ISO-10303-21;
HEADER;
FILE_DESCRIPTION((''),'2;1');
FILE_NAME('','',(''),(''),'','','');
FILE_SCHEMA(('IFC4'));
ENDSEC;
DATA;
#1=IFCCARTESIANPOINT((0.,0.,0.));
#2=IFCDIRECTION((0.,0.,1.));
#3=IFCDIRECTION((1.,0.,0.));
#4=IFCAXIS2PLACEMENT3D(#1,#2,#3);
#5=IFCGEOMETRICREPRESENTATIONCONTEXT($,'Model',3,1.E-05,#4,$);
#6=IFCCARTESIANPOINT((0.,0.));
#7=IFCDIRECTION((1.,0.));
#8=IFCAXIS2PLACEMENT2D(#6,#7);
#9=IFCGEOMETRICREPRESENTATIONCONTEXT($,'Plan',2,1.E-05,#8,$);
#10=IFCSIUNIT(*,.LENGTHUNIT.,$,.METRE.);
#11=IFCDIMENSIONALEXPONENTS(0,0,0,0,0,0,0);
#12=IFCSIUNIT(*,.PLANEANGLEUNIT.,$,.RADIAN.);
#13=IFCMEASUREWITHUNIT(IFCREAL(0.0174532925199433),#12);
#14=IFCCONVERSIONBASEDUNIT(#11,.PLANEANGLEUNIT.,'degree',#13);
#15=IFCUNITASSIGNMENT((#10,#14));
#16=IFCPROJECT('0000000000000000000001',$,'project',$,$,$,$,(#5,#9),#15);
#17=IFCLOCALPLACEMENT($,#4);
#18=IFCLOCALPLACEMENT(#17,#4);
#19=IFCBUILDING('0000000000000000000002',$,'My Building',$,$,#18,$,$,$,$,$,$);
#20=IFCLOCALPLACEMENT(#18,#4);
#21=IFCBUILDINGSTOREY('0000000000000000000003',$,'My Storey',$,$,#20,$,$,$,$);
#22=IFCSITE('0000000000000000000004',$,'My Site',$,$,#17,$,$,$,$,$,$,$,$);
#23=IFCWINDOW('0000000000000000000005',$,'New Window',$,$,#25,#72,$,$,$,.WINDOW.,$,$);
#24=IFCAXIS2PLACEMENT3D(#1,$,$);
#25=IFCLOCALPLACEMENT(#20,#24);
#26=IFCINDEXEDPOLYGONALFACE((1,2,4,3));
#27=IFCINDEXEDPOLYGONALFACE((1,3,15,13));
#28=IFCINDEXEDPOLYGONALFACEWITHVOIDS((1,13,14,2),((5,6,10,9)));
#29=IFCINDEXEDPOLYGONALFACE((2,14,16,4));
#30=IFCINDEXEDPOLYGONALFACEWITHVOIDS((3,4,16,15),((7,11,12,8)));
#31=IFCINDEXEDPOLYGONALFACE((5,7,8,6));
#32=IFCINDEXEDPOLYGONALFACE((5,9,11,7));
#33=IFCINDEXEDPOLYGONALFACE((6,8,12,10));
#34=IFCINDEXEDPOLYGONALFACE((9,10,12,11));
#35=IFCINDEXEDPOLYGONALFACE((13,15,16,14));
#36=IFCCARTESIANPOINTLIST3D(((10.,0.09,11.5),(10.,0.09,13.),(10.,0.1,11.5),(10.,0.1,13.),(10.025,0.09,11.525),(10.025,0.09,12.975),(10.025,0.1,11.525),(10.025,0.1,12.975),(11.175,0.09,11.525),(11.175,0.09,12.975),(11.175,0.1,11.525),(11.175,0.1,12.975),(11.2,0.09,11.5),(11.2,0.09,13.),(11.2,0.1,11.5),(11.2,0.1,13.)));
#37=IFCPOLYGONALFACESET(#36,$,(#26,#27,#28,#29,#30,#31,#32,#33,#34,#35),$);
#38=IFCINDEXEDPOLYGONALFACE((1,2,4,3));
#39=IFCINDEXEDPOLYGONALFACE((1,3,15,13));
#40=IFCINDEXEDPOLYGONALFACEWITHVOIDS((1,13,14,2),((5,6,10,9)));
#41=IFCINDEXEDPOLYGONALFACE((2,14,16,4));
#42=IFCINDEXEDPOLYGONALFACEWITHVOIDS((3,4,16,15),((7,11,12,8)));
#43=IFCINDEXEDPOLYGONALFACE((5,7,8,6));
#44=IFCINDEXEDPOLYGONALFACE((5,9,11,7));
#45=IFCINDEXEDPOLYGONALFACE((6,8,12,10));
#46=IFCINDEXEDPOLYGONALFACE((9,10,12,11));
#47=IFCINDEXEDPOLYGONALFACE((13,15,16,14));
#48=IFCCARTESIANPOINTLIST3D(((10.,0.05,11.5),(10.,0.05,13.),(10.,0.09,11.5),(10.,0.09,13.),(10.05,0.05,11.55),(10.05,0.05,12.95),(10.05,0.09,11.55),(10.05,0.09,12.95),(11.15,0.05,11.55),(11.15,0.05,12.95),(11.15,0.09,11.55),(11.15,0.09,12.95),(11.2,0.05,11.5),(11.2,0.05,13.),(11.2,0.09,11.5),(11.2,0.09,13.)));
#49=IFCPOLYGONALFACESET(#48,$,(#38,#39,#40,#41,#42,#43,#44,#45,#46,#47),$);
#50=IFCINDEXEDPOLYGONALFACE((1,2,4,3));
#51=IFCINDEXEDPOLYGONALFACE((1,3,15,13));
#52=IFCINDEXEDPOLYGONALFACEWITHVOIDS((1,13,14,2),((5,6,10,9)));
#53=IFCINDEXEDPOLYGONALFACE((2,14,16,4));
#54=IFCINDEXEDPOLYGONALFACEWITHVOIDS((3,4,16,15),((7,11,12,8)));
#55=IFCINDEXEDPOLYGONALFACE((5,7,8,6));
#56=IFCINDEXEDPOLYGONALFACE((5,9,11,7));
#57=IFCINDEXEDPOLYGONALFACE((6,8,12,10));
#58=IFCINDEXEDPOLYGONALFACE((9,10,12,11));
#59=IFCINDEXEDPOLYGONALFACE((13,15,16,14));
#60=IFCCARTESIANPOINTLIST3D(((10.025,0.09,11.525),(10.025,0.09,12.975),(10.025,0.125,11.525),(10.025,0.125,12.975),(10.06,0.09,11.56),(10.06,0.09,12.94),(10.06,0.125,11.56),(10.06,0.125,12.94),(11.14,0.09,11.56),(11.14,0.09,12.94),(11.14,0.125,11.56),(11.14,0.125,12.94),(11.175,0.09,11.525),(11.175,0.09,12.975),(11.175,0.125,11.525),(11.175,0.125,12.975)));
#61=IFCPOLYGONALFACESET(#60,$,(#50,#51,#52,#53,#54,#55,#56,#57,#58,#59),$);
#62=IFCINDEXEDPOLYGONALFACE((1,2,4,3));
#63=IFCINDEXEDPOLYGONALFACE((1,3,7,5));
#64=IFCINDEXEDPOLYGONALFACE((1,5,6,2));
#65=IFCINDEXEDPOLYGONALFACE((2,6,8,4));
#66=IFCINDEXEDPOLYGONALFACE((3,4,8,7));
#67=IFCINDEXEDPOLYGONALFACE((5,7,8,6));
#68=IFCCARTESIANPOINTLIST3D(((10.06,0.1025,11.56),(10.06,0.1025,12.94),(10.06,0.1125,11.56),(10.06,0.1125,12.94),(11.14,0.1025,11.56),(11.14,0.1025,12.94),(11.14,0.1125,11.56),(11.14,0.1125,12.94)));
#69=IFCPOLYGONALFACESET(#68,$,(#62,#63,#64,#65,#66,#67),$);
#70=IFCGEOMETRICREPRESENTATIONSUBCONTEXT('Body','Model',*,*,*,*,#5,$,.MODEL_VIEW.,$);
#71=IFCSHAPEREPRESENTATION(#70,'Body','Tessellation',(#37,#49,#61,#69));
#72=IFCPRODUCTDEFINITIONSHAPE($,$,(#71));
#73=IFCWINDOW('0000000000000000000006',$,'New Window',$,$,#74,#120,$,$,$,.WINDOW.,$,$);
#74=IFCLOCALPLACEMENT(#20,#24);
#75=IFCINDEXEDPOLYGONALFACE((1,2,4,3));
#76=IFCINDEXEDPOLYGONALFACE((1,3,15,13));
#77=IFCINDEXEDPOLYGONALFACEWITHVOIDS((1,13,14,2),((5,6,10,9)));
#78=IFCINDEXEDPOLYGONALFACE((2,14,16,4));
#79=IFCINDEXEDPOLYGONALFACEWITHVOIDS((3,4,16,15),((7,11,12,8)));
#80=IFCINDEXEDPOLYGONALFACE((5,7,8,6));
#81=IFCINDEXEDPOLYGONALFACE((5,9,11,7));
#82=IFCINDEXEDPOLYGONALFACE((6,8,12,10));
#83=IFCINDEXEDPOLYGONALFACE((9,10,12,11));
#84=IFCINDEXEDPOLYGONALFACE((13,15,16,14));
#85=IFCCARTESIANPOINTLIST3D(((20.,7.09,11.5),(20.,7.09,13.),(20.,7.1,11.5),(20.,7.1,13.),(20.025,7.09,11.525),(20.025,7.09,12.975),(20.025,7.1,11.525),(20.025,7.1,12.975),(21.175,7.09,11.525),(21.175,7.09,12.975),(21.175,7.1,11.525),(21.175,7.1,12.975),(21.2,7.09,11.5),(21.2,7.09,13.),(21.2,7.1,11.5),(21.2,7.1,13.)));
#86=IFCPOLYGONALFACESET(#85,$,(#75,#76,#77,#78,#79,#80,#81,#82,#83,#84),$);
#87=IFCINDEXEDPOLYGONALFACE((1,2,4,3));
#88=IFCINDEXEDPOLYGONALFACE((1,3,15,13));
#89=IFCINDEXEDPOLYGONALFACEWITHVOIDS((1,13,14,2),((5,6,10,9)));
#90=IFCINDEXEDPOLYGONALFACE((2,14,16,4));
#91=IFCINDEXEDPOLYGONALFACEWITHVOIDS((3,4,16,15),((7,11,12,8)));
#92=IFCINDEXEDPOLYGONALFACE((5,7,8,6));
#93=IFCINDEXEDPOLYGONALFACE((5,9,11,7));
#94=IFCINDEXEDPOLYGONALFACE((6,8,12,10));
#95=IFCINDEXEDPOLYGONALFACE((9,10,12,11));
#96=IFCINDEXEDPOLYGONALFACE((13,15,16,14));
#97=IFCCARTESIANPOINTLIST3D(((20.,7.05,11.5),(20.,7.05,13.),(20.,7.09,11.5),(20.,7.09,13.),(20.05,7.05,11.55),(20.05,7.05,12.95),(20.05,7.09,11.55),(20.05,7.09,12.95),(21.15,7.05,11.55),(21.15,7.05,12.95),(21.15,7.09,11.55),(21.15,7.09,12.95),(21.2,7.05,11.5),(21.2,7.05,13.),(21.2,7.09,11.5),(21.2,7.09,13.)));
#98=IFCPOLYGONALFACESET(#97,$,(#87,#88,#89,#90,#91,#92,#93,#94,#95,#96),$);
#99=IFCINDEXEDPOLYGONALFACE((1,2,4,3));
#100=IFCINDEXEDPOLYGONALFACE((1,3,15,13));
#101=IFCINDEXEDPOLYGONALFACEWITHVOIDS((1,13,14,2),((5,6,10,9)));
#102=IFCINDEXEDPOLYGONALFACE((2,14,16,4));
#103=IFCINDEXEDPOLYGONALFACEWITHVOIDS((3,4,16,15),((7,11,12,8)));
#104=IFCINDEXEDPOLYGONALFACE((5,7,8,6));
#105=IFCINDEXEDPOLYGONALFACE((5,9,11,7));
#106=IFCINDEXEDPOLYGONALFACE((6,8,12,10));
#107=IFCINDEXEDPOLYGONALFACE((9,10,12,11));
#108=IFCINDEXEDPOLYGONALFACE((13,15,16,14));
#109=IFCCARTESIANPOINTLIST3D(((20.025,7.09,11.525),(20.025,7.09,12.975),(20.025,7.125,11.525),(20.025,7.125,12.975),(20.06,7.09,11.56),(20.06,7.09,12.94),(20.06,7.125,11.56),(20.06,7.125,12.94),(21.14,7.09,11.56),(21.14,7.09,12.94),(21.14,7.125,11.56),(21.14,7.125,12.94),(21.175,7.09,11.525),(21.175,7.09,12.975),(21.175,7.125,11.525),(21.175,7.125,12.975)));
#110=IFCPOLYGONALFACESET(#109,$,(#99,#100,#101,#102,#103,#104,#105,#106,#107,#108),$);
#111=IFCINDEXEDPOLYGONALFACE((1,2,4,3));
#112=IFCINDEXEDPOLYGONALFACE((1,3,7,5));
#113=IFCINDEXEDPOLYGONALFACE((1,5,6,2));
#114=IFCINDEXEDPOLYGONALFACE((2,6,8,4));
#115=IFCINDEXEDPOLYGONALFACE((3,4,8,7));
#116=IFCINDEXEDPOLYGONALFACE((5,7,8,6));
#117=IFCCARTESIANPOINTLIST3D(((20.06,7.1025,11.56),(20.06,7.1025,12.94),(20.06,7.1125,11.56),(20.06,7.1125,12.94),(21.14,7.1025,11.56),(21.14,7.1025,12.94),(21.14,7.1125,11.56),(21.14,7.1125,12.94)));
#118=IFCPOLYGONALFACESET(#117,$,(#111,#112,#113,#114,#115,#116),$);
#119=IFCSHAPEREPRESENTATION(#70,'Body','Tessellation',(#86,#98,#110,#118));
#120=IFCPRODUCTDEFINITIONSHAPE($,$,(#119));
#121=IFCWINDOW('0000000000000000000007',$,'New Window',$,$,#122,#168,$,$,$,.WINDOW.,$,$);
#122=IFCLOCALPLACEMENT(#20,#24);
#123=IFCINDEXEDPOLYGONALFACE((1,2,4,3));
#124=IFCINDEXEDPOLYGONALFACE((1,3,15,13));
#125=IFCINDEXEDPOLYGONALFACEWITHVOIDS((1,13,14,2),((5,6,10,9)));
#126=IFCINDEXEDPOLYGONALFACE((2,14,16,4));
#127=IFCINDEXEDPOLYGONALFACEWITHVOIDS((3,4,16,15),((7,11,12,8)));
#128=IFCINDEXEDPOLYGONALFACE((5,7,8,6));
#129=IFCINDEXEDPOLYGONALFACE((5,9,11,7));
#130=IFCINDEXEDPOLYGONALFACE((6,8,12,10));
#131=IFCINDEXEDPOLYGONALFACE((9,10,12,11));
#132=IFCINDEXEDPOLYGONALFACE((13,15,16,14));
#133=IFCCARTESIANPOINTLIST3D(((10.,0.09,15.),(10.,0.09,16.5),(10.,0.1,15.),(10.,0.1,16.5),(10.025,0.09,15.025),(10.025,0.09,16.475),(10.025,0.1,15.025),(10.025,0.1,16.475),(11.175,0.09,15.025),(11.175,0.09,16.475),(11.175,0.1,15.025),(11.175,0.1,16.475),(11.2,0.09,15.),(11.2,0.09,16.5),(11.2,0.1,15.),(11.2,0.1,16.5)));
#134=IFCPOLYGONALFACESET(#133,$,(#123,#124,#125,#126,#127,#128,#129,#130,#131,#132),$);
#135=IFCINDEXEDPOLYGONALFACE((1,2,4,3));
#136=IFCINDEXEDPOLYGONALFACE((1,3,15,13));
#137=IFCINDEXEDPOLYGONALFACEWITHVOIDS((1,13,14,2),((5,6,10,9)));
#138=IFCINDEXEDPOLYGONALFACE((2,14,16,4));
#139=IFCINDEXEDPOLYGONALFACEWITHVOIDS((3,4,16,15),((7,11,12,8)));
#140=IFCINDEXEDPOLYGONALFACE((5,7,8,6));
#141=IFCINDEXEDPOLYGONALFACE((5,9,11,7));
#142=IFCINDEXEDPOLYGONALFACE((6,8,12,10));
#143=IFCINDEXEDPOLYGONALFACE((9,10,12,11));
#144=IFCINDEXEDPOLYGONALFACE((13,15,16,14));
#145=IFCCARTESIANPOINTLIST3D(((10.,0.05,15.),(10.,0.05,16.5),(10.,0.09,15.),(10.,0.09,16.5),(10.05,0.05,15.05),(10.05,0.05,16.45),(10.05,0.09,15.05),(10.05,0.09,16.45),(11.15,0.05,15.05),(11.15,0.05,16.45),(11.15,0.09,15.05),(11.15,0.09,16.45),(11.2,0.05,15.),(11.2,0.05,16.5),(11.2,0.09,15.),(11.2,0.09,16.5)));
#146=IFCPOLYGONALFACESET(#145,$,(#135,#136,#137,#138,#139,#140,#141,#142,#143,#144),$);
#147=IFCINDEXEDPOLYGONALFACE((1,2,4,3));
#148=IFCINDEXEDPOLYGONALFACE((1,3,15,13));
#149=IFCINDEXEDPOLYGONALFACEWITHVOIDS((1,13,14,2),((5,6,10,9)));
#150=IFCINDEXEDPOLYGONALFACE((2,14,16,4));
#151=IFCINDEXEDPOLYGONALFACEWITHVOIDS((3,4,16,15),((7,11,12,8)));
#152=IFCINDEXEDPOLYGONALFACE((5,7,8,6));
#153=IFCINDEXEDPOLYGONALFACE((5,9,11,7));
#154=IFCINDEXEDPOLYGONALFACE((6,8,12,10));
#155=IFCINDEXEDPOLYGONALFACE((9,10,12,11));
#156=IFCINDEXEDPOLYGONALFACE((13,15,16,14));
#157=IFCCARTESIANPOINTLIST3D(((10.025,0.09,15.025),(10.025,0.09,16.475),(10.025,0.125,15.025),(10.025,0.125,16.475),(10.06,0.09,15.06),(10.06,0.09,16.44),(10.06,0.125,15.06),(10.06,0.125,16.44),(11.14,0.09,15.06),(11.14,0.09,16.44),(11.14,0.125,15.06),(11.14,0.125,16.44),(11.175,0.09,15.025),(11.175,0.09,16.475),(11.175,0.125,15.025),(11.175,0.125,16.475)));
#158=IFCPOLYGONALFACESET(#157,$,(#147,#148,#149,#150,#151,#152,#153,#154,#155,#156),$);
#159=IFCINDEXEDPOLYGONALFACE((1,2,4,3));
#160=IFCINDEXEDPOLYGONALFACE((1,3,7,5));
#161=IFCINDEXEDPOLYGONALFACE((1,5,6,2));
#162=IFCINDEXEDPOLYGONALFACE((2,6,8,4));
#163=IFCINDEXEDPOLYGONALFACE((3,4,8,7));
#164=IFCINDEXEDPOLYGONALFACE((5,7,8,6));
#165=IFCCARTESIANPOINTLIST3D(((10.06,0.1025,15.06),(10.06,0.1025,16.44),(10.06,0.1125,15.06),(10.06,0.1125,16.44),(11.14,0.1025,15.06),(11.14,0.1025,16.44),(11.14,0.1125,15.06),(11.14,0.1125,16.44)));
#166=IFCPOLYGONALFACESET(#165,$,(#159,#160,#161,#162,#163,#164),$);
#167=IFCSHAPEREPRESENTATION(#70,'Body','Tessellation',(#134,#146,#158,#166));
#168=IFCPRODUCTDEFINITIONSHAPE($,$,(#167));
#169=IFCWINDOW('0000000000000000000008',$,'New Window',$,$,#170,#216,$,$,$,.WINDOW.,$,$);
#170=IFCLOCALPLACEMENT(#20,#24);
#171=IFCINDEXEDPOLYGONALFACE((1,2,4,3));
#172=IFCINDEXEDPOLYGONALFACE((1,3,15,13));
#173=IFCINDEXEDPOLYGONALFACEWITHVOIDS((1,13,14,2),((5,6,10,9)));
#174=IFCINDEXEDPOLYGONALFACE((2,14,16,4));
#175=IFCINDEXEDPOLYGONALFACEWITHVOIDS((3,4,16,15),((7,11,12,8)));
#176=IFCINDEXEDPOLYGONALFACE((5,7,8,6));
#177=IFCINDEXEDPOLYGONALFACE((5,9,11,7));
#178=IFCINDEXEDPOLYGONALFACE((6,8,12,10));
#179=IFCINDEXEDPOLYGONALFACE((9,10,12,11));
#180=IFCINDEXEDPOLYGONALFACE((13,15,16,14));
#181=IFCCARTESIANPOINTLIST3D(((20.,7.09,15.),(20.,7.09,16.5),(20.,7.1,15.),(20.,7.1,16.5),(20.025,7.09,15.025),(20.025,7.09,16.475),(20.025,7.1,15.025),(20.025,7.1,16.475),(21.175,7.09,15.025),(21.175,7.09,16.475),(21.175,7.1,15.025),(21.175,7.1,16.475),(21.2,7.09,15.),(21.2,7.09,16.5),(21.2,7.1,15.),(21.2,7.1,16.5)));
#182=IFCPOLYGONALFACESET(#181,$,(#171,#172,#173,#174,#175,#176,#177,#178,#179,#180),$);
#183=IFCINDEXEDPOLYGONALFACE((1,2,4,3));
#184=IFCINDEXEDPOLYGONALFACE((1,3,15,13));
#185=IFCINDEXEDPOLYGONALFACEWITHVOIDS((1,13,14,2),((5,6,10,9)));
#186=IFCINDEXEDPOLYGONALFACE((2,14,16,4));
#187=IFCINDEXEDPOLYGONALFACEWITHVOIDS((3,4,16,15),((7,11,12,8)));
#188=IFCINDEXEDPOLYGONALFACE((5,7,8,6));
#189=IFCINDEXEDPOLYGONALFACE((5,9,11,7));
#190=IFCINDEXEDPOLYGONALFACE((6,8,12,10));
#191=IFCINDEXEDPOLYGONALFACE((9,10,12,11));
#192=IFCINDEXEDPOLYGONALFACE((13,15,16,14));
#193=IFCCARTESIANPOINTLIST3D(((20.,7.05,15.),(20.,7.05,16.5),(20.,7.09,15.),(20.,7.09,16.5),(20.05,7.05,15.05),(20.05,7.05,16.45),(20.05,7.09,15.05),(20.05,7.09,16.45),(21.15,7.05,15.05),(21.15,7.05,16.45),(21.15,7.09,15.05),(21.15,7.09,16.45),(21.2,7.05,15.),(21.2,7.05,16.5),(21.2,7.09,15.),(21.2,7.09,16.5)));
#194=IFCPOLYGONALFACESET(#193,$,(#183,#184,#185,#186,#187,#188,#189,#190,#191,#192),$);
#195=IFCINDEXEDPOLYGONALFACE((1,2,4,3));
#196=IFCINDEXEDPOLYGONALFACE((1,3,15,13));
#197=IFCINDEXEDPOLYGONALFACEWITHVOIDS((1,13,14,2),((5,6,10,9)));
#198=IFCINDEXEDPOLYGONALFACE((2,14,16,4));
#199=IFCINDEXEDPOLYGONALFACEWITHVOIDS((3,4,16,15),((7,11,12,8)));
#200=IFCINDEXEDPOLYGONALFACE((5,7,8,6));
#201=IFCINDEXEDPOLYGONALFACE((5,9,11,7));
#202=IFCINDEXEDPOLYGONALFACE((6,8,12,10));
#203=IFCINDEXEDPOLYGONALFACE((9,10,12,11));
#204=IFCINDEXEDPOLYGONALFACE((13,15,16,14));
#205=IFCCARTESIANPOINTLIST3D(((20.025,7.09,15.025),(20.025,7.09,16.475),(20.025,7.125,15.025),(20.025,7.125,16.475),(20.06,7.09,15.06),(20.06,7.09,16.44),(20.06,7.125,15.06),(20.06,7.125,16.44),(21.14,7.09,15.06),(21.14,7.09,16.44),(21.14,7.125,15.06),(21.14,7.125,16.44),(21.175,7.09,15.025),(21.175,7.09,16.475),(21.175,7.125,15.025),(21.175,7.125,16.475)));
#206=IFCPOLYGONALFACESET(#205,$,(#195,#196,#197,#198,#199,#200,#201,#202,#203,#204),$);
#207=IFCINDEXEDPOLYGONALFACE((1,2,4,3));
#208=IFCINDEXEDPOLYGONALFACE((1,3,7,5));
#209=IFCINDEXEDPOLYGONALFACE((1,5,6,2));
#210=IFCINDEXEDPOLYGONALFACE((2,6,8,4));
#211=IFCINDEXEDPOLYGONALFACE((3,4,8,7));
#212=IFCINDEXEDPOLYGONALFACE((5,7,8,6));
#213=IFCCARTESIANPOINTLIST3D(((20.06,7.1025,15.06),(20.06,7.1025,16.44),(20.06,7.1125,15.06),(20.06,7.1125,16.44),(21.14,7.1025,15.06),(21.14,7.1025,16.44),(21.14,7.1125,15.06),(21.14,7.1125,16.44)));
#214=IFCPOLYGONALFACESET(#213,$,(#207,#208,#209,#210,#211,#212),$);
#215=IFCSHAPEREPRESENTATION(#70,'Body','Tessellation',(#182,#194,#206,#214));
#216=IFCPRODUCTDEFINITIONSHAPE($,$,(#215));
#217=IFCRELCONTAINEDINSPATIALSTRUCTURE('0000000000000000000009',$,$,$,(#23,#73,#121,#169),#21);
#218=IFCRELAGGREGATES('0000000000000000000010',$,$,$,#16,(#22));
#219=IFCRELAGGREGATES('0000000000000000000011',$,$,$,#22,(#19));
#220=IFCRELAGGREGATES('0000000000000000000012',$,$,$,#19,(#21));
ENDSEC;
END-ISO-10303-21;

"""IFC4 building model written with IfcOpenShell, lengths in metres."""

from ifc_helpers import new_model, entity, si_unit, converted_unit, frame, origin_with_axes, origin_2d_with_axis, place, context, subcontext, project, spatial, line, indexed_curve, outline, extrude, element, save


model = new_model("IFC4")

# Units and contexts
model_context = context("Model", 3, precision=1e-05, world=origin_with_axes())
plan_context = context("Plan", 2, precision=1e-05, world=origin_2d_with_axis())
body_context = subcontext(model_context, "Body", "Model", "MODEL_VIEW")
ifc_project = project(units=[si_unit("LENGTHUNIT", "METRE"), converted_unit("PLANEANGLEUNIT", "degree", entity("IfcReal", 0.0174532925199433), si_unit("PLANEANGLEUNIT", "RADIAN"), dimensions=[0, 0, 0, 0, 0, 0, 0])], contexts=[model_context, plan_context])

# Site, building, storey
site_placement = place(None, origin_with_axes())
site = spatial("IfcSite", under=ifc_project, at=site_placement, Name="My Site")
building_placement = place(site_placement, origin_with_axes())
building = spatial("IfcBuilding", under=site, at=building_placement, Name="My Building")
storey_placement = place(building_placement, origin_with_axes())
storey = spatial("IfcBuildingStorey", under=building, at=storey_placement, Name="My Storey")

# Windows
for number, where, z_axis, x_axis, name in (
    (1, (10.0, 0.0, 11.5), (0.0, 0.0, 1.0), (1.0, 0.0, 0.0), "New Window"),
    (2, (20.0, 7.0, 11.5), (0.0, 0.0, 1.0), (1.0, 0.0, 0.0), "New Window"),
    (3, (10.0, 0.0, 15.0), (0.0, 0.0, 1.0), (1.0, 0.0, 0.0), "New Window"),
    (4, (20.0, 7.0, 15.0), (0.0, 0.0, 1.0), (1.0, 0.0, 0.0), "New Window"),
):
    element("IfcWindow", number, at=place(storey_placement, frame(where, z_axis=z_axis, x_axis=x_axis)), inside=storey, Name=name, PredefinedType="WINDOW", context=body_context, shape_type="SweptSolid", body=[
        extrude(outline(indexed_curve([(0.0, 0.0), (1.2, 0.0), (1.2, 1.5), (0.0, 1.5)], segments=[line(1, 2, 3, 4, 1)]), holes=[indexed_curve([(0.025, 0.025), (1.175, 0.025), (1.175, 1.475), (0.025, 1.475)], segments=[line(1, 2, 3, 4, 1)])]), frame((0.0, 0.09, 0.0), z_axis=(0.0, -1.0, 0.0), x_axis=(1.0, 0.0, 0.0)), (0.0, 0.0, -1.0), 0.01),
        extrude(outline(indexed_curve([(0.0, 0.0), (1.2, 0.0), (1.2, 1.5), (0.0, 1.5)], segments=[line(1, 2, 3, 4, 1)]), holes=[indexed_curve([(0.05, 0.05), (1.15, 0.05), (1.15, 1.45), (0.05, 1.45)], segments=[line(1, 2, 3, 4, 1)])]), frame((0.0, 0.05, 0.0), z_axis=(0.0, -1.0, 0.0), x_axis=(1.0, 0.0, 0.0)), (0.0, 0.0, -1.0), 0.04),
        extrude(outline(indexed_curve([(0.0, 0.0), (1.15, 0.0), (1.15, 1.45), (0.0, 1.45)], segments=[line(1, 2, 3, 4, 1)]), holes=[indexed_curve([(0.035, 0.035), (1.115, 0.035), (1.115, 1.415), (0.035, 1.415)], segments=[line(1, 2, 3, 4, 1)])]), frame((0.025, 0.09, 0.025), z_axis=(0.0, -1.0, 0.0), x_axis=(1.0, 0.0, 0.0)), (0.0, 0.0, -1.0), 0.035),
        extrude(outline(indexed_curve([(0.035, 0.035), (1.115, 0.035), (1.115, 1.415), (0.035, 1.415)], segments=[line(1, 2, 3, 4, 1)])), frame((0.025, 0.1025, 0.025), z_axis=(0.0, -1.0, 0.0), x_axis=(1.0, 0.0, 0.0)), (0.0, 0.0, -1.0), 0.01),
    ])

save(model, "model.ifc")
